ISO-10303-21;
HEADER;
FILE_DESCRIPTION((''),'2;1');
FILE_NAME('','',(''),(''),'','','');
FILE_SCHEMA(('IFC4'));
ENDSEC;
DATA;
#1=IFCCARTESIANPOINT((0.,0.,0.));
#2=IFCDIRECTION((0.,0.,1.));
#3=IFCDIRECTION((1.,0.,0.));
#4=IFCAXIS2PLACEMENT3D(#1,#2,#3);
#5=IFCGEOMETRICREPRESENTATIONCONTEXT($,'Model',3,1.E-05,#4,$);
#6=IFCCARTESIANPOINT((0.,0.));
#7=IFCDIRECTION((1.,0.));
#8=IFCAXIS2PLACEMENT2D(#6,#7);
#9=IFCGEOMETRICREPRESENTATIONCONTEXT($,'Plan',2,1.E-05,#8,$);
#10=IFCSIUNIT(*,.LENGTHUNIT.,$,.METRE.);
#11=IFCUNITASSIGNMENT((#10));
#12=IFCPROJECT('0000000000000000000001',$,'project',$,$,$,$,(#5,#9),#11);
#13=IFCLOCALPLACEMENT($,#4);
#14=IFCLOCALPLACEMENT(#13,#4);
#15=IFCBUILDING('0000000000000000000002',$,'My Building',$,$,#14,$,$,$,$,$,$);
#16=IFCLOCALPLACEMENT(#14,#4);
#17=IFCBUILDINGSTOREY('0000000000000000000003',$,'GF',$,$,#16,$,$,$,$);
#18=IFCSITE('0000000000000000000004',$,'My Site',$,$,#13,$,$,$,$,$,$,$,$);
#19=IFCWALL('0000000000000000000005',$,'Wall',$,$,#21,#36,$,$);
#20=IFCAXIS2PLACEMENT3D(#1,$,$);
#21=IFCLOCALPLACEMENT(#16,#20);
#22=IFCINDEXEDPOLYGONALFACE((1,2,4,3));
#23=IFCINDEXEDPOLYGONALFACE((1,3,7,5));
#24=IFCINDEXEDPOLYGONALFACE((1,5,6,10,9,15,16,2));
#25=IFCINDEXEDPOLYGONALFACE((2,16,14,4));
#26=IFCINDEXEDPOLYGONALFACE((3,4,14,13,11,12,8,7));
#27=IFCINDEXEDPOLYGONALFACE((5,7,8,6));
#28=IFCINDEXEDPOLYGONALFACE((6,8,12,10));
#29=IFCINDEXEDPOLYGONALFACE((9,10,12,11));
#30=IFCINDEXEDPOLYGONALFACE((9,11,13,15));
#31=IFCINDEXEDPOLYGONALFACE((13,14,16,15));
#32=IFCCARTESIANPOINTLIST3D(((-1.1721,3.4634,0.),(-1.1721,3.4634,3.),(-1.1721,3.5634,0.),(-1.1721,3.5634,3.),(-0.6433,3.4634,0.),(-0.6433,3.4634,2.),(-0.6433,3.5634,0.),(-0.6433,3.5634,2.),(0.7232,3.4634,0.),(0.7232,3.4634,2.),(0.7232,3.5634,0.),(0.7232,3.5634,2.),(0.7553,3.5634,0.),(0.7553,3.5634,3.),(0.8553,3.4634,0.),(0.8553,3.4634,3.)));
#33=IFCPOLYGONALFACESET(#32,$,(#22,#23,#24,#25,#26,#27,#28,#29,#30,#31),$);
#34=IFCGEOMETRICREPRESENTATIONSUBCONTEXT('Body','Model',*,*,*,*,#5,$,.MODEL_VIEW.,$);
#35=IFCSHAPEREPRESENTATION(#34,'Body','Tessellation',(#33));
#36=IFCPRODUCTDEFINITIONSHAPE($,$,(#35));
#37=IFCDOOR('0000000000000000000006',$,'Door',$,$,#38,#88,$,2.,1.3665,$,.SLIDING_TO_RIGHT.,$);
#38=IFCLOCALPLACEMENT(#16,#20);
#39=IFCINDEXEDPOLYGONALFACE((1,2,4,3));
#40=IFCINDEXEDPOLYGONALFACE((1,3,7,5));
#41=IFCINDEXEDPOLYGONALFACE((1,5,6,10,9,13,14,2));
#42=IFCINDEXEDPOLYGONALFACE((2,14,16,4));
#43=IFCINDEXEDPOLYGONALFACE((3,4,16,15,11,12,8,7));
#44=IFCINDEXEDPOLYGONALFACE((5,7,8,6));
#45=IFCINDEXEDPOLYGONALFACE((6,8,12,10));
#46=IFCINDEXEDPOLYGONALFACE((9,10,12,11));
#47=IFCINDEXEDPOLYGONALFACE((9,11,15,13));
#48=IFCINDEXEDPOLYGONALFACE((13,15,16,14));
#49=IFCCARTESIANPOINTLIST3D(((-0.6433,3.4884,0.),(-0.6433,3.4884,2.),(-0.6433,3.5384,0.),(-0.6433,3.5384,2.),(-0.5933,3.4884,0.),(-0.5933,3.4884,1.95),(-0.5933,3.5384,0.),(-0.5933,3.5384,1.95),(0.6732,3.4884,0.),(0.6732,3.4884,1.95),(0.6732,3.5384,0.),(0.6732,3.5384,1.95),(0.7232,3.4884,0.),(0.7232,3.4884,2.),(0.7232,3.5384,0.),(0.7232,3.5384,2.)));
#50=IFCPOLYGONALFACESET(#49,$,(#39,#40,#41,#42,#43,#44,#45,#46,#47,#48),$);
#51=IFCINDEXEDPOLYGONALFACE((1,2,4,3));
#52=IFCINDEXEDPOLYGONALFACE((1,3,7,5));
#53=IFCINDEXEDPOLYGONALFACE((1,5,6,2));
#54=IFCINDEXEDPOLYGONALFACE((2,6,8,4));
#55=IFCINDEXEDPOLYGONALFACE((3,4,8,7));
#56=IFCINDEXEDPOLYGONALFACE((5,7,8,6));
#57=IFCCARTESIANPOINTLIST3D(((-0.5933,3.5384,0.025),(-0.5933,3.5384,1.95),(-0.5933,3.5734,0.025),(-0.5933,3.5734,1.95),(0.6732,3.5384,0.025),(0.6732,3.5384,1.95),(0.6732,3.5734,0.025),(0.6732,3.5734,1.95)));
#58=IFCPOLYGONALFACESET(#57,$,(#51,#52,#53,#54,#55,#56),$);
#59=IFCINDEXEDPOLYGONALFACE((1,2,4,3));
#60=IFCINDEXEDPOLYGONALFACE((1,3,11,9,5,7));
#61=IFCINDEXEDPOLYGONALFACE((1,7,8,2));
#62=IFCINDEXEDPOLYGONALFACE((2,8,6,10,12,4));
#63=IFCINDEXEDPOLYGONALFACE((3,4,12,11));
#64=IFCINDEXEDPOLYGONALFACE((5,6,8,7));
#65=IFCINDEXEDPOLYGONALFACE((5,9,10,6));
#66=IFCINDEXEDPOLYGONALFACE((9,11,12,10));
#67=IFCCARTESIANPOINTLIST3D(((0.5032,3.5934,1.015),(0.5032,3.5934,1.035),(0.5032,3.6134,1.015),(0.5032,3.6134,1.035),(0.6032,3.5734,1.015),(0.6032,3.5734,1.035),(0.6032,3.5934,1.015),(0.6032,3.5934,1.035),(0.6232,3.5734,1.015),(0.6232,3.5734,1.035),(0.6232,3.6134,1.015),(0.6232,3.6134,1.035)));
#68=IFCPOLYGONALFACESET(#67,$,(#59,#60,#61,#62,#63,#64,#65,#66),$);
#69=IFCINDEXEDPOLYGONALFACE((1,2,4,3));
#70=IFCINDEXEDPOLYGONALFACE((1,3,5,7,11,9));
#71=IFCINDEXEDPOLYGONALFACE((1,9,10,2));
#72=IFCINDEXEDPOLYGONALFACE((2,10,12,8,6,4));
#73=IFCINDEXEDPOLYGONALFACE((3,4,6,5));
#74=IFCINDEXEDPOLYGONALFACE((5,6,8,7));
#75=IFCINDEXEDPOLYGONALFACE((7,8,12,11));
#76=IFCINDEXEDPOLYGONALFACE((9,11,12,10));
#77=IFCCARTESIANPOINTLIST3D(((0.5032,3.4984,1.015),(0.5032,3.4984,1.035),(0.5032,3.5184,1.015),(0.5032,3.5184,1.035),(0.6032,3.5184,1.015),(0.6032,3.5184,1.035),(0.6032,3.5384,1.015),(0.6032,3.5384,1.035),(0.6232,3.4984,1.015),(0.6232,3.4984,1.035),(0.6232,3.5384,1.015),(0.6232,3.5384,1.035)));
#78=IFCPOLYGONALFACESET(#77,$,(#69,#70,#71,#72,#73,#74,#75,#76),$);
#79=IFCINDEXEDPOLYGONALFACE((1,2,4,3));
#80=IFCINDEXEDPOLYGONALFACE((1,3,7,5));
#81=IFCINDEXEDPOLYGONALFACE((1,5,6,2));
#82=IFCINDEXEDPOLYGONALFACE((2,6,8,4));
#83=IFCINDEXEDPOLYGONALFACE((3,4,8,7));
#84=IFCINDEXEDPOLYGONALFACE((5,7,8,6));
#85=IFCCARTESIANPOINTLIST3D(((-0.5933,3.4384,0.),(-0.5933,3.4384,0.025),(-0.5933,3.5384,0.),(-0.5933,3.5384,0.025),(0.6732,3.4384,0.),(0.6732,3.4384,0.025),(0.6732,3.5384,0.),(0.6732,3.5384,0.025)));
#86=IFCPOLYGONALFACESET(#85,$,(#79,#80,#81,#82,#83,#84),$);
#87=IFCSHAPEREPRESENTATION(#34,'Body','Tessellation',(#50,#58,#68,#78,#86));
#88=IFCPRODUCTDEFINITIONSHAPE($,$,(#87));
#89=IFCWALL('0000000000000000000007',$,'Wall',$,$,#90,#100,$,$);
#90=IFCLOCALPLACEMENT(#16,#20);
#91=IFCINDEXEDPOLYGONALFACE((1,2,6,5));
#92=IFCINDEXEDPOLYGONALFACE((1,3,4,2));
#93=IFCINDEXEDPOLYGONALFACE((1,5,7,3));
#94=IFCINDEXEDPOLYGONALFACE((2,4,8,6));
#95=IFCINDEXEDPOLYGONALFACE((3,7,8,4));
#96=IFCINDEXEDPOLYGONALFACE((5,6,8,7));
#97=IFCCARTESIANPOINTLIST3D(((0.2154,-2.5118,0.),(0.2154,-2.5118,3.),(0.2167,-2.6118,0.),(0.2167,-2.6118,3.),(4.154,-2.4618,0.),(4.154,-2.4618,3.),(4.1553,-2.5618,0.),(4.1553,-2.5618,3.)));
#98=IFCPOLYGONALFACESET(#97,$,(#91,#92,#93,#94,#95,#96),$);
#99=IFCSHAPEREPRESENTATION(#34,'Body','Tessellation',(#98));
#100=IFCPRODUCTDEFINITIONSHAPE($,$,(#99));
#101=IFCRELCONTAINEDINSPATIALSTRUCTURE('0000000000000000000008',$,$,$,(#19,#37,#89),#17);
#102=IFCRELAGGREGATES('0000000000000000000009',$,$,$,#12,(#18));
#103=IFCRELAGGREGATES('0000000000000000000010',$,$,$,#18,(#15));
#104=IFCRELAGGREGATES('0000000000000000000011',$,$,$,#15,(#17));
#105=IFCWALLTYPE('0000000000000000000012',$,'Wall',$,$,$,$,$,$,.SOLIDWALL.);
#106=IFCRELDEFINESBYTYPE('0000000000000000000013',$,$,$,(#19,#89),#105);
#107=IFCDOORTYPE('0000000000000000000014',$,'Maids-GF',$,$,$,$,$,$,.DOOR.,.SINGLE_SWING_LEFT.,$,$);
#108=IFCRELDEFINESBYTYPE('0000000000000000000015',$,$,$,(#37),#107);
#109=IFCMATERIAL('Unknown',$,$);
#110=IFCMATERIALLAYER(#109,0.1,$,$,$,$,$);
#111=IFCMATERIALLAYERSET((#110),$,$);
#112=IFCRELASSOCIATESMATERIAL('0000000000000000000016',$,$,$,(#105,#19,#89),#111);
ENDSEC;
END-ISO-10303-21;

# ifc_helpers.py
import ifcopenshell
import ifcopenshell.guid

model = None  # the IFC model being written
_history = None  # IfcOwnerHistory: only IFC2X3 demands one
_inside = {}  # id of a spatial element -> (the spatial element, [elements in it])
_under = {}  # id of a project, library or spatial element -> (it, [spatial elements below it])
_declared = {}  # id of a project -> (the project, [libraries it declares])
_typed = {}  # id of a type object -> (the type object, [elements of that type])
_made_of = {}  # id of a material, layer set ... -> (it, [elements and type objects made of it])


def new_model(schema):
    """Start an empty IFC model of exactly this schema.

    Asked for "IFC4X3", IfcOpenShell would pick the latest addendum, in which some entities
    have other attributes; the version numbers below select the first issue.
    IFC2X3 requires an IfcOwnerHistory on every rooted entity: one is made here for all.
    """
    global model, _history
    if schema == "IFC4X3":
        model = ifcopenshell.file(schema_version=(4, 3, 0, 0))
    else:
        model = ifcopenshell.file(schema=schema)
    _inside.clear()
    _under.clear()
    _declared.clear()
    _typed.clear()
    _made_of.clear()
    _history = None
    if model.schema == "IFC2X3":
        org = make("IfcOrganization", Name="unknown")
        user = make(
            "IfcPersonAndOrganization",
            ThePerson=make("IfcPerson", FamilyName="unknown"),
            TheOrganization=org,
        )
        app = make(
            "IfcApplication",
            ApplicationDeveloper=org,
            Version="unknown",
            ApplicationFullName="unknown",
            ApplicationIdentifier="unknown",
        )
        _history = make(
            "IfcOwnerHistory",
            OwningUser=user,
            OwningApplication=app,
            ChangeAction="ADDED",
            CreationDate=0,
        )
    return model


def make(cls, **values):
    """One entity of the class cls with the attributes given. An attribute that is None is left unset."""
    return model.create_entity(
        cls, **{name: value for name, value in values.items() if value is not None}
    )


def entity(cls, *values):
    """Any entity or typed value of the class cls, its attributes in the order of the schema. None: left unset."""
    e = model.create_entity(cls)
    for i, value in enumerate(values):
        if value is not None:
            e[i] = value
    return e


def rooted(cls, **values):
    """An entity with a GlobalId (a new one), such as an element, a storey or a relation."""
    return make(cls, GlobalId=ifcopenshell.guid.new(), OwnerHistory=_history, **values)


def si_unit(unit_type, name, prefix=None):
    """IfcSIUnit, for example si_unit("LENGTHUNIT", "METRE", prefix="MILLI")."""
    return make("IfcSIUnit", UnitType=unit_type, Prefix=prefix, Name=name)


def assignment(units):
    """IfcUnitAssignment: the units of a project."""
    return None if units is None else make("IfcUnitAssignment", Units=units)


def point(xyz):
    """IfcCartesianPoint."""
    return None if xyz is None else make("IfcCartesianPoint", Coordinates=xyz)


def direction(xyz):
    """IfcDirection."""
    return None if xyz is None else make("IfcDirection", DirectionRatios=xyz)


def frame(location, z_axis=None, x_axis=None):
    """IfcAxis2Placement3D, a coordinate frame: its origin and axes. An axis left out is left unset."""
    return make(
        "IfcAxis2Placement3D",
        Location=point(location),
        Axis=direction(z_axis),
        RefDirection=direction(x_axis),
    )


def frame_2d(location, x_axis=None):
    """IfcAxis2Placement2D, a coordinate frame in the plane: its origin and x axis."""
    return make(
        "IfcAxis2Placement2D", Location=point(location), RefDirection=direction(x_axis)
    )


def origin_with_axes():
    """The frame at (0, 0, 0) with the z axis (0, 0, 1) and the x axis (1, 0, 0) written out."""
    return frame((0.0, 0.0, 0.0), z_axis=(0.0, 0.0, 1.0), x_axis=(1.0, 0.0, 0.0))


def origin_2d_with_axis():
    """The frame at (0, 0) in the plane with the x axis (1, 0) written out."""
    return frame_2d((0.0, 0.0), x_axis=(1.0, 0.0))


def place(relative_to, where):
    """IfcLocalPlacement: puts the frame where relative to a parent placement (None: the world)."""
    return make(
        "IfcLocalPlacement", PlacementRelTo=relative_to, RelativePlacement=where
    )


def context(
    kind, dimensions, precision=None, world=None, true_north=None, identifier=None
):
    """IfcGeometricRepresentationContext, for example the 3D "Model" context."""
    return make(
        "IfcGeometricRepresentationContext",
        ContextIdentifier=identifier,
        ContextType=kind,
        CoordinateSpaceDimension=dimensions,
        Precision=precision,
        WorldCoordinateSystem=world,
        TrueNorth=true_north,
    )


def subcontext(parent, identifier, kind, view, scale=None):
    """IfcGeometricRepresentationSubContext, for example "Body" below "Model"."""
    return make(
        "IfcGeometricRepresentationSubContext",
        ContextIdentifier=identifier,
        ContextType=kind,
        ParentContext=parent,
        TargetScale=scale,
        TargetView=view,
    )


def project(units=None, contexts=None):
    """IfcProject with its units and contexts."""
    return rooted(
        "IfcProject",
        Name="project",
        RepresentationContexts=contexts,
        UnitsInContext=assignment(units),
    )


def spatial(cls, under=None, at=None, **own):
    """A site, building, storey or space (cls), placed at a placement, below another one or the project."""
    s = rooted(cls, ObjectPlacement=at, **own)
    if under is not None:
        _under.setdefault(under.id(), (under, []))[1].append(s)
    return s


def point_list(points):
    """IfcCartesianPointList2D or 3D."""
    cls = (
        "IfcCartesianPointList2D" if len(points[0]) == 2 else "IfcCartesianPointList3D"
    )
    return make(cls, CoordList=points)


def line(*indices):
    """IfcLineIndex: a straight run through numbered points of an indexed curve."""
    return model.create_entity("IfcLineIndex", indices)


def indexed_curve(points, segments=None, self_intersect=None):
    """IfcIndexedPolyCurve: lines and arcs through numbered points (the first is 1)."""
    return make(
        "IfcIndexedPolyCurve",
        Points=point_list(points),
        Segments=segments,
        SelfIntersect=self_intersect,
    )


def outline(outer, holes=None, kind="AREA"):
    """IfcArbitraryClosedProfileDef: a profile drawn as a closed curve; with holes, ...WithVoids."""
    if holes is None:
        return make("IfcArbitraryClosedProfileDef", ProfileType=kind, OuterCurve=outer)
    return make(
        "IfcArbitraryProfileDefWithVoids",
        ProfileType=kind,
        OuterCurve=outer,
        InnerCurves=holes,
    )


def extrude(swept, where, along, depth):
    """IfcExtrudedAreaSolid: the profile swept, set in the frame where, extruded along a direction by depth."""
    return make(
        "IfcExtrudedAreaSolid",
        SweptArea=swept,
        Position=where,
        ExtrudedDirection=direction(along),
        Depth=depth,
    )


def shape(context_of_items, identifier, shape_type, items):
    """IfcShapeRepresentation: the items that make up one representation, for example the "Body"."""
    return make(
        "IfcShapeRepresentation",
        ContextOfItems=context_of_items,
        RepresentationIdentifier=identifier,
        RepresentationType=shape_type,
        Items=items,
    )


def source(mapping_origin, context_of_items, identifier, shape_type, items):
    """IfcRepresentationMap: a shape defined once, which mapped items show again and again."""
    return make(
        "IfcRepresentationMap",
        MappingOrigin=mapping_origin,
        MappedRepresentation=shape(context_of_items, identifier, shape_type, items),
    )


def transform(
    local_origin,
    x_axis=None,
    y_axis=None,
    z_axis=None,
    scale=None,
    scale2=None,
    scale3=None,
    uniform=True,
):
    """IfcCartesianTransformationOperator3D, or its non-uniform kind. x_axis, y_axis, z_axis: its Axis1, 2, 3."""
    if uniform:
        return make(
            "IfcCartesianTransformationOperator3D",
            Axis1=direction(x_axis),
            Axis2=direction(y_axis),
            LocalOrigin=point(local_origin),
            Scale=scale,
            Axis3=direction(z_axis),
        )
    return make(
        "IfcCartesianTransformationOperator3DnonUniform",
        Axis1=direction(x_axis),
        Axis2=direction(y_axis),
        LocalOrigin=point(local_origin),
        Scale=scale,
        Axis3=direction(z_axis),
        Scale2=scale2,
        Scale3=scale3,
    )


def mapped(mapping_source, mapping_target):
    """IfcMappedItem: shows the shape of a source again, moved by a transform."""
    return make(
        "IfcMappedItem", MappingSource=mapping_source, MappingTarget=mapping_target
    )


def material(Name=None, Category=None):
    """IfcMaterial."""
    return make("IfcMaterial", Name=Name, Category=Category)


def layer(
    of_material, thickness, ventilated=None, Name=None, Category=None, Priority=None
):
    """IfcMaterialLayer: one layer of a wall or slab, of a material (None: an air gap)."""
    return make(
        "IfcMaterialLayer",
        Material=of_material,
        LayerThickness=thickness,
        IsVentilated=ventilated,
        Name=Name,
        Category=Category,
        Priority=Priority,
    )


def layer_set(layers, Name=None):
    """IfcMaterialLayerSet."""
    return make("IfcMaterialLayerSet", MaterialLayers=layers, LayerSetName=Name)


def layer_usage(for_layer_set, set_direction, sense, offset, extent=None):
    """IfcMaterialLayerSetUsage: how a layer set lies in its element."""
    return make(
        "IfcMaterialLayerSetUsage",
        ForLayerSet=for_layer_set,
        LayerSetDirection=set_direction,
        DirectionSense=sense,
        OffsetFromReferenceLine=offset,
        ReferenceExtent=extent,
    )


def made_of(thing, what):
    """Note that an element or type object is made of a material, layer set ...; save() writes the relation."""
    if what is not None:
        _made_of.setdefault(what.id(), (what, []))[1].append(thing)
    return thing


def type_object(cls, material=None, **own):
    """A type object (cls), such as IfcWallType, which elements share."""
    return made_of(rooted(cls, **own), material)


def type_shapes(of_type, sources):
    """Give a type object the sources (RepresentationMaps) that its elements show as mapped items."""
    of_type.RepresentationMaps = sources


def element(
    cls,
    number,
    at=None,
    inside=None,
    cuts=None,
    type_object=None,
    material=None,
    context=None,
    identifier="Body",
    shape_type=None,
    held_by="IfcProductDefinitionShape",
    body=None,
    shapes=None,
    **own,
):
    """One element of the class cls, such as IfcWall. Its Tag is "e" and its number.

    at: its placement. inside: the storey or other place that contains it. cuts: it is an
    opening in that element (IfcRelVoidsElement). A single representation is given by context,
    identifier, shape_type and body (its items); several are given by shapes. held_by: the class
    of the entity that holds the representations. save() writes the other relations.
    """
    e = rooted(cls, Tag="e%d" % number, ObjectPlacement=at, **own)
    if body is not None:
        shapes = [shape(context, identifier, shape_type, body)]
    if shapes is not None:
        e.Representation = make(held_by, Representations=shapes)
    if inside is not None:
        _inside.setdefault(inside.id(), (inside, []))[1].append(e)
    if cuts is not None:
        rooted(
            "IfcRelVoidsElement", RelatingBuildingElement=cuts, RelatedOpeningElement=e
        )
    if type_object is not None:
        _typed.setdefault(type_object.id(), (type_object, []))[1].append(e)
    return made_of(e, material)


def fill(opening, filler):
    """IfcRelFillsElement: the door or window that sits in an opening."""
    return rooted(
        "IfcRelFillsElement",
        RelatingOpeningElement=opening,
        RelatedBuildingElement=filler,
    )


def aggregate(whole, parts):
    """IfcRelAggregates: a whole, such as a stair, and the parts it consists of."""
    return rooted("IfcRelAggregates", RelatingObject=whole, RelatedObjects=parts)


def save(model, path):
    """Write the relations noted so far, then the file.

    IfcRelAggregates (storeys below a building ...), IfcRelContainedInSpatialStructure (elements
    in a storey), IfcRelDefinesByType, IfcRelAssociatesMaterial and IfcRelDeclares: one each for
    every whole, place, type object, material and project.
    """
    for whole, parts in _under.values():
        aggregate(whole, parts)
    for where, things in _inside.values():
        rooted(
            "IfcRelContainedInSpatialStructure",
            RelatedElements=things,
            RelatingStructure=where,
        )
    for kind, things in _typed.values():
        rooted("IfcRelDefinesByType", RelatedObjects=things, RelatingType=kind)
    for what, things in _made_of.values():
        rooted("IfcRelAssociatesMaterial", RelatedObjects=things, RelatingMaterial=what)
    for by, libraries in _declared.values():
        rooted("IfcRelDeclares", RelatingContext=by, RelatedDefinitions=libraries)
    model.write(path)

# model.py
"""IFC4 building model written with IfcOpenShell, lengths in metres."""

from ifc_helpers import new_model, entity, si_unit, frame, origin_with_axes, origin_2d_with_axis, place, context, subcontext, project, spatial, line, indexed_curve, outline, extrude, shape, source, transform, mapped, material, layer, layer_set, layer_usage, type_object, type_shapes, element, fill, save


model = new_model("IFC4")

# Units and contexts
model_context = context("Model", 3, precision=1e-05, world=origin_with_axes())
plan_context = context("Plan", 2, precision=1e-05, world=origin_2d_with_axis())
body_context_1 = subcontext(model_context, "Body", "Model", "MODEL_VIEW")
body_context_2 = subcontext(plan_context, "Body", "Plan", "PLAN_VIEW")
ifc_project = project(units=[si_unit("LENGTHUNIT", "METRE")], contexts=[model_context, plan_context])

# Site, building, storey
site_placement = place(None, origin_with_axes())
site = spatial("IfcSite", under=ifc_project, at=site_placement, Name="My Site")
building_placement = place(site_placement, origin_with_axes())
building = spatial("IfcBuilding", under=site, at=building_placement, Name="My Building")
storey_placement = place(building_placement, origin_with_axes())
storey = spatial("IfcBuildingStorey", under=building, at=storey_placement, Name="GF")

# Shared definitions
ifc_material = material(Name="Unknown")

# Shared definitions
ifc_layer_1 = layer(ifc_material, 0.1)
ifc_layer_set_1 = layer_set([ifc_layer_1])
wall_type = type_object("IfcWallType", Name="Wall", PredefinedType="SOLIDWALL", material=ifc_layer_set_1)

# Wall, opening, door
ifc_layer_usage_1 = layer_usage(ifc_layer_set_1, "AXIS2", "POSITIVE", 0.0)
wall_1_placement = place(storey_placement, frame((0.7553, 3.5634, 0.0), z_axis=(0.0, 0.0, 1.0), x_axis=(-1.0, 0.0, 0.0)))
wall_1 = element("IfcWall", 1, at=wall_1_placement, inside=storey, type_object=wall_type, material=ifc_layer_usage_1, Name="Wall", context=body_context_1, shape_type="SweptSolid", body=[
    extrude(outline(indexed_curve([(0.0, 0.0), (-0.1, 0.1), (1.9273, 0.1), (1.9273, 0.0)], segments=[line(1, 2, 3, 4, 1)])), origin_with_axes(), (0.0, 0.0, 1.0), 3.0),
])
shared_shape_1 = source(origin_with_axes(), body_context_1, "Body", "SweptSolid", [
    extrude(outline(indexed_curve([(0.0, 0.0), (1.3665, 0.0), (1.3665, 2.0), (0.0, 2.0)], segments=[line(1, 2, 3, 4, 1)])), frame((0.0, -0.6, 0.0), z_axis=(0.0, -1.0, 0.0), x_axis=(1.0, 0.0, 0.0)), (0.0, 0.0, -1.0), 1.2),
])
opening_1_placement = place(wall_1_placement, frame((0.0321, 0.025, 0.0), z_axis=(0.0, 0.0, 1.0), x_axis=(1.0, 0.0, 0.0)))
opening_1 = element("IfcOpeningElement", 2, at=opening_1_placement, cuts=wall_1, PredefinedType="OPENING", context=body_context_1, shape_type="MappedRepresentation", body=[
    mapped(shared_shape_1, transform((0.0, 0.0, 0.0), x_axis=(1.0, 0.0, 0.0), y_axis=(0.0, 1.0, 0.0), z_axis=(0.0, 0.0, 1.0), scale=1.0)),
])
door_type_1 = type_object("IfcDoorType", Name="Maids-GF", OperationType="SINGLE_SWING_LEFT", PredefinedType="DOOR")
shared_shape_2 = source(origin_with_axes(), body_context_1, "Body", "SweptSolid", [
    extrude(outline(indexed_curve([(0.0, 0.0), (0.0, 2.0), (1.3665, 2.0), (1.3665, 0.0), (1.3165, 0.0), (1.3165, 1.95), (0.05, 1.95), (0.05, 0.0)], segments=[line(1, 2, 3, 4, 5, 6, 7, 8, 1)])), frame((0.0, 0.0, 0.0), z_axis=(0.0, -1.0, 0.0), x_axis=(1.0, 0.0, 0.0)), (0.0, 0.0, -1.0), 0.05),
    extrude(outline(indexed_curve([(0.0, 0.0), (1.2665, 0.0), (1.2665, 0.035), (0.0, 0.035)], segments=[line(1, 2, 3, 4, 1)])), frame((0.05, -0.035, 0.025), z_axis=(0.0, 0.0, 1.0), x_axis=(1.0, 0.0, 0.0)), (0.0, 0.0, 1.0), 1.925),
    extrude(outline(indexed_curve([(0.0, 0.0), (0.0, -0.04), (0.12, -0.04), (0.12, -0.02), (0.02, -0.02), (0.02, 0.0)], segments=[line(1, 2, 3, 4, 5, 6, 1)])), frame((0.1, -0.035, 1.015), z_axis=(0.0, 0.0, 1.0), x_axis=(1.0, 0.0, 0.0)), (0.0, 0.0, 1.0), 0.02),
    extrude(outline(indexed_curve([(0.0, 0.0), (0.0, 0.04), (0.12, 0.04), (0.12, 0.02), (0.02, 0.02), (0.02, 0.0)], segments=[line(1, 2, 3, 4, 5, 6, 1)])), frame((0.1, 0.0, 1.015), z_axis=(0.0, 0.0, 1.0), x_axis=(1.0, 0.0, 0.0)), (0.0, 0.0, 1.0), 0.02),
    extrude(outline(indexed_curve([(0.0, 0.0), (1.2665, 0.0), (1.2665, 0.1), (0.0, 0.1)], segments=[line(1, 2, 3, 4, 1)])), frame((0.05, 0.0, 0.0), z_axis=(0.0, 0.0, 1.0), x_axis=(1.0, 0.0, 0.0)), (0.0, 0.0, 1.0), 0.025),
])
shared_shape_3 = source(origin_with_axes(), body_context_2, "Body", "Curve2D", [
    entity("IfcIndexedPolyCurve", entity("IfcCartesianPointList2D", [[0.0, 0.0], [0.05, 0.0], [0.05, 0.05], [0.0, 0.05]]), [entity("IfcLineIndex", [1, 2, 3, 4, 1])]),
    entity("IfcIndexedPolyCurve", entity("IfcCartesianPointList2D", [[1.3665, 0.0], [1.3165, 0.0], [1.3165, 0.05], [1.3665, 0.05]]), [entity("IfcLineIndex", [1, 2, 3, 4, 1])]),
    entity("IfcIndexedPolyCurve", entity("IfcCartesianPointList2D", [[1.9498, -0.035], [0.6833, -0.035], [0.6833, 0.0], [1.9498, 0.0]]), [entity("IfcLineIndex", [1, 2, 3, 4, 1])]),
])
type_shapes(door_type_1, [shared_shape_2, shared_shape_3])
door_1_placement = place(opening_1_placement, frame((0.0, 0.0, 0.0), z_axis=(0.0, 0.0, 1.0), x_axis=(1.0, 0.0, 0.0)))
door_1 = element("IfcDoor", 3, at=door_1_placement, inside=storey, type_object=door_type_1, Name="Door", OperationType="SLIDING_TO_RIGHT", OverallHeight=2.0, OverallWidth=1.3665, shapes=[
    shape(body_context_1, "Body", "MappedRepresentation", [mapped(shared_shape_2, transform((0.0, 0.0, 0.0), x_axis=(1.0, 0.0, 0.0), y_axis=(0.0, 1.0, 0.0), z_axis=(0.0, 0.0, 1.0), scale=1.0))]),
    shape(body_context_2, "Body", "MappedRepresentation", [mapped(shared_shape_3, transform((0.0, 0.0, 0.0), x_axis=(1.0, 0.0, 0.0), y_axis=(0.0, 1.0, 0.0), z_axis=(0.0, 0.0, 1.0), scale=1.0))]),
])
fill(opening_1, door_1)

# Wall
ifc_layer_usage_2 = layer_usage(ifc_layer_set_1, "AXIS2", "POSITIVE", 0.0)
wall_2_placement = place(storey_placement, frame((0.2167, -2.6118, 0.0), z_axis=(0.0, 0.0, 1.0), x_axis=(0.999919, 0.012694, 0.0)))
element("IfcWall", 4, at=wall_2_placement, inside=storey, type_object=wall_type, material=ifc_layer_usage_2, Name="Wall", context=body_context_1, shape_type="SweptSolid", body=[
    extrude(outline(indexed_curve([(0.0, 0.0), (0.0, 0.1), (3.939, 0.1), (3.939, 0.0)], segments=[line(1, 2, 3, 4, 1)])), origin_with_axes(), (0.0, 0.0, 1.0), 3.0),
])

save(model, "model.ifc")
